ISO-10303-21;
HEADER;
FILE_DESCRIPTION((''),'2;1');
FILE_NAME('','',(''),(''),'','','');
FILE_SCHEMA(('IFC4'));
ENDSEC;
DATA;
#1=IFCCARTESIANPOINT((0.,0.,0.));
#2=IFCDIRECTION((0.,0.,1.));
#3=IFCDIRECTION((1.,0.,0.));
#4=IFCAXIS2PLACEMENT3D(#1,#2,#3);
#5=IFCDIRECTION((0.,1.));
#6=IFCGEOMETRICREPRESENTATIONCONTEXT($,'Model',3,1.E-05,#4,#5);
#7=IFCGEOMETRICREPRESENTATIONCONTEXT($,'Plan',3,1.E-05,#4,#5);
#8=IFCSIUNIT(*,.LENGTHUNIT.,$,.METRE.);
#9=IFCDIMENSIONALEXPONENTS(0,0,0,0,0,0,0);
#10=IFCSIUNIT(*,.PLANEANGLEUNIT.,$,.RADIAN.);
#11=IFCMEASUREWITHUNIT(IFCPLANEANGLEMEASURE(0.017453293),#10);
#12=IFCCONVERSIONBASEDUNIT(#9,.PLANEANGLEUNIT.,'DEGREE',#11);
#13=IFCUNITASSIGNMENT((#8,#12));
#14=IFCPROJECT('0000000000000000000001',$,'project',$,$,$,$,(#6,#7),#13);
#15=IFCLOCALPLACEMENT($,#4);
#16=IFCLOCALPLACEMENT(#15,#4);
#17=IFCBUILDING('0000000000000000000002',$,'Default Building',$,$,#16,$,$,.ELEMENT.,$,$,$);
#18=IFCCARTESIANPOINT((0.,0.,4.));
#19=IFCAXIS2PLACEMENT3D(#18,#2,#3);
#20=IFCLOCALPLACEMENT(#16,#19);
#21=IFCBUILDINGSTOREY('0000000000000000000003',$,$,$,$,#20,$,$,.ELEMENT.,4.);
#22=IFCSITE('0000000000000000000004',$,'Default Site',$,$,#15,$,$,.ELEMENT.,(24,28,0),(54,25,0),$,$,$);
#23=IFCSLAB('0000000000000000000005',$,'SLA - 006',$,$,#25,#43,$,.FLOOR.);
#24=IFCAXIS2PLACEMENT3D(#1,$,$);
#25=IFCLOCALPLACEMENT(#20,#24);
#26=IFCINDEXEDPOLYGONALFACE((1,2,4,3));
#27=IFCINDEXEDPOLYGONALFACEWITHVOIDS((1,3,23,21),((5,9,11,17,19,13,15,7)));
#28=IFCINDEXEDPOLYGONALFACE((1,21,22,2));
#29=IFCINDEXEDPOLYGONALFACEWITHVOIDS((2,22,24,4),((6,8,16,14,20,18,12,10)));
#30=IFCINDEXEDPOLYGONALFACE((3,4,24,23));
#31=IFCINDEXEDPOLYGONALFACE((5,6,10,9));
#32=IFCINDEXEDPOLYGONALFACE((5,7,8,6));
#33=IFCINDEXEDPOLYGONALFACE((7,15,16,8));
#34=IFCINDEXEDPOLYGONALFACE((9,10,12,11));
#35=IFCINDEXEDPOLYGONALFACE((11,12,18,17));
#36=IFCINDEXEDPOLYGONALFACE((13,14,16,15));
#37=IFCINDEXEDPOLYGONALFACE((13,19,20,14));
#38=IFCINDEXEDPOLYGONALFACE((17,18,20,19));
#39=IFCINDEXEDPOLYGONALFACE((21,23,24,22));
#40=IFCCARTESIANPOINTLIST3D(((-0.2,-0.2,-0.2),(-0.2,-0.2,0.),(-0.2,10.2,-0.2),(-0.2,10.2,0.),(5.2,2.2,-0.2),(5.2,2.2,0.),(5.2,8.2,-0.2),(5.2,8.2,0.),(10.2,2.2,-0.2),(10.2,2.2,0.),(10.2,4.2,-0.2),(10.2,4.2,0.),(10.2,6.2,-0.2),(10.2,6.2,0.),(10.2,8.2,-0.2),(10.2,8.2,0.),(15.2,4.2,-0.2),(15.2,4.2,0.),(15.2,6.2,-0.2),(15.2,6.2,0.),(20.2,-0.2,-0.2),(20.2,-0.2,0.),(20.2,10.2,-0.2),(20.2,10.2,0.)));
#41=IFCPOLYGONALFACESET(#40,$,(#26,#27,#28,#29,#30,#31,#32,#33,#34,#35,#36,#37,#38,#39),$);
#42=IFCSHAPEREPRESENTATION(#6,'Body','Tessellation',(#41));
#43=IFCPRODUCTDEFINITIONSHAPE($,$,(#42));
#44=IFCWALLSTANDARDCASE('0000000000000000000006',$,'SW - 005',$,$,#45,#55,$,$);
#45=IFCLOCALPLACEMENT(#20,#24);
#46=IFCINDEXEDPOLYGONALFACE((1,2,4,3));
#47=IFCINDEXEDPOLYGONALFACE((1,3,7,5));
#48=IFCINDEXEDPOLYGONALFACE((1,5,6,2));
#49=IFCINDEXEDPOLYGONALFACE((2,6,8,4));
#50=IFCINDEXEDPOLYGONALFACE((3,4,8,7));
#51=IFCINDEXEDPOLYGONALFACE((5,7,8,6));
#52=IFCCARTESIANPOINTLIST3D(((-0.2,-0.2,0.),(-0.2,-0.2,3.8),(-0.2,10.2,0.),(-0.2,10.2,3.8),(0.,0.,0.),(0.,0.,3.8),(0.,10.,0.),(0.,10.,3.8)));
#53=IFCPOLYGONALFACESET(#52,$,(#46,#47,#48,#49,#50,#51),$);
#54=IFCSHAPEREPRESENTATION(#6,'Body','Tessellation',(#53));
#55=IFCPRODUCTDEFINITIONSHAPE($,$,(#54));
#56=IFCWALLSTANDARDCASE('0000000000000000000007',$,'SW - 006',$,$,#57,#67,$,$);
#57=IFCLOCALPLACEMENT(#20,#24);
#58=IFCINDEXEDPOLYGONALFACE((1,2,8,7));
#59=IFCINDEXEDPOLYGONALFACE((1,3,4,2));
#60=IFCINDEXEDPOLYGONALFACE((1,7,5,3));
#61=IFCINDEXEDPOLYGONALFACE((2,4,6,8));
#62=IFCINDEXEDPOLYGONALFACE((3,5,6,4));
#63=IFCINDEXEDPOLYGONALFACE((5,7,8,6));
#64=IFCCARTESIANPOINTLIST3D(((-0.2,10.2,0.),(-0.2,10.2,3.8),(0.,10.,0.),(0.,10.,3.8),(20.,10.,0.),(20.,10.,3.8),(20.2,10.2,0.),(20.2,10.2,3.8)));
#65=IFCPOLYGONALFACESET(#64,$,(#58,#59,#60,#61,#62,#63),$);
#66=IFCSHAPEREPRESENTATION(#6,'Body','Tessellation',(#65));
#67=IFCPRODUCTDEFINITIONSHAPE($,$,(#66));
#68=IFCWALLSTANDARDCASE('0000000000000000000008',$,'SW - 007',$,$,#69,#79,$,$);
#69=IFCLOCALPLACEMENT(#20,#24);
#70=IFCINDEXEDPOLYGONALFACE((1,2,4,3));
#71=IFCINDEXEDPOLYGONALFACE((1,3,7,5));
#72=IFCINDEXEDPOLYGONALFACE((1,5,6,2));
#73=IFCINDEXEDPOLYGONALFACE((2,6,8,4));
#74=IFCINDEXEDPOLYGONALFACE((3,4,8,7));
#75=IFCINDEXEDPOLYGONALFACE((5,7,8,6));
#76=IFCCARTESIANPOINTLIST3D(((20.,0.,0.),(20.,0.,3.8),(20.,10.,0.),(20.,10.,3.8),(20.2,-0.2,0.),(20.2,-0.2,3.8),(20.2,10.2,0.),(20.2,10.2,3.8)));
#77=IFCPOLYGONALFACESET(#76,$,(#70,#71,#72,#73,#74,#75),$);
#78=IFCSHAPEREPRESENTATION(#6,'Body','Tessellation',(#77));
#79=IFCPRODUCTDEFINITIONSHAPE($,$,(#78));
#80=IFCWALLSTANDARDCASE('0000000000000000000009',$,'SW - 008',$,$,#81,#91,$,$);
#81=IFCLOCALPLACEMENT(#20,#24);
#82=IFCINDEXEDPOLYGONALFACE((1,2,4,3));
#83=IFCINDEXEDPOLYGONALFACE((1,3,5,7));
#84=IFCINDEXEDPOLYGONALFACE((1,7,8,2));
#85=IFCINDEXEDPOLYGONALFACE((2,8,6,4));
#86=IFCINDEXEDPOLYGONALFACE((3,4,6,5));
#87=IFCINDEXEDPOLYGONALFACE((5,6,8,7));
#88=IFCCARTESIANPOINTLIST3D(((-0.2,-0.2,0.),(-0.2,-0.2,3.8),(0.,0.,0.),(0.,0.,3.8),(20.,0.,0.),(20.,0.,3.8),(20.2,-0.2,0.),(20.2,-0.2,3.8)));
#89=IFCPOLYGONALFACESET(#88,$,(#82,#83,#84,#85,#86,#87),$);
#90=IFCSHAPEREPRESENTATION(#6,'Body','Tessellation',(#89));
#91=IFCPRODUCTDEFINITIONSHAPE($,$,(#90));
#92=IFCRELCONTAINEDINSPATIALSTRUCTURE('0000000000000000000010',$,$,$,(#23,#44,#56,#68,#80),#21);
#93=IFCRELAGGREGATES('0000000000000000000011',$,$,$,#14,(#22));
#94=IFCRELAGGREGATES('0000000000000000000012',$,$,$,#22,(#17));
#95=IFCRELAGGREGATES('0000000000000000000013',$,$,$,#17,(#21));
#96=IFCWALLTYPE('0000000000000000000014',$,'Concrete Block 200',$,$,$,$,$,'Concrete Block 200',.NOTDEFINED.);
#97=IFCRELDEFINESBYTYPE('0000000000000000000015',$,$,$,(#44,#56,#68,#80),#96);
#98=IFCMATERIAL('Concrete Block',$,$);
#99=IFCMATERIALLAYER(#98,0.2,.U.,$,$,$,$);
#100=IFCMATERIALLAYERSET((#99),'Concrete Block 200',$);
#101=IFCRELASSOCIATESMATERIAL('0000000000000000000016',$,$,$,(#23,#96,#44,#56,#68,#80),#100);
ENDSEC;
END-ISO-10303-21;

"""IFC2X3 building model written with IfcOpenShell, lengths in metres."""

from ifc_helpers import new_model, entity, si_unit, converted_unit, direction, frame, origin_with_axes, place, context, project, spatial, polyline, outline, extrude, material, layer, layer_set, layer_usage, type_object, element, save


model = new_model("IFC2X3")

# Units and contexts
model_context = context("Model", 3, precision=1e-05, world=origin_with_axes(), true_north=direction((0.0, 1.0)))
plan_context = context("Plan", 3, precision=1e-05, world=origin_with_axes(), true_north=direction((0.0, 1.0)))
ifc_project = project(units=[si_unit("LENGTHUNIT", "METRE"), converted_unit("PLANEANGLEUNIT", "DEGREE", entity("IfcPlaneAngleMeasure", 0.017453293), si_unit("PLANEANGLEUNIT", "RADIAN"), dimensions=[0, 0, 0, 0, 0, 0, 0])], contexts=[model_context, plan_context])

# Site, building, storey
site_placement = place(None, origin_with_axes())
site = spatial("IfcSite", under=ifc_project, at=site_placement, Name="Default Site", CompositionType="ELEMENT", RefLatitude=(24, 28, 0), RefLongitude=(54, 25, 0))
building_placement = place(site_placement, origin_with_axes())
building = spatial("IfcBuilding", under=site, at=building_placement, Name="Default Building", CompositionType="ELEMENT")
storey_placement = place(building_placement, frame((0.0, 0.0, 4.0), z_axis=(0.0, 0.0, 1.0), x_axis=(1.0, 0.0, 0.0)))
storey = spatial("IfcBuildingStorey", under=building, at=storey_placement, CompositionType="ELEMENT", Elevation=4.0)

# Slab, opening
ifc_material = material(Name="Concrete Block")
ifc_layer = layer(ifc_material, 0.2, ventilated="UNKNOWN")
ifc_layer_set = layer_set([ifc_layer], Name="Concrete Block 200")
ifc_layer_usage_1 = layer_usage(ifc_layer_set, "AXIS3", "NEGATIVE", 0.2)
slab_placement = place(storey_placement, frame((20.2, 10.2, -0.2), z_axis=(0.0, 0.0, 1.0), x_axis=(-1.0, 0.0, 0.0)))
slab = element("IfcSlab", 1, at=slab_placement, inside=storey, material=ifc_layer_usage_1, Name="SLA - 006", PredefinedType="FLOOR", context=model_context, shape_type="SweptSolid", body=[
    extrude(outline(polyline([(0.0, 0.0), (20.4, 0.0), (20.4, 10.4), (0.0, 10.4), (0.0, 0.0)])), origin_with_axes(), (0.0, 0.0, 1.0), 0.2),
])
opening_placement = place(slab_placement, origin_with_axes())
element("IfcOpeningElement", 2, at=opening_placement, cuts=slab, context=model_context, shape_type="SweptSolid", body=[
    extrude(outline(polyline([(10.0, 8.0), (15.0, 8.0), (15.0, 2.0), (10.0, 2.0), (10.0, 4.0), (5.0, 4.0), (5.0, 6.0), (10.0, 6.0), (10.0, 8.0)])), origin_with_axes(), (0.0, 0.0, 1.0), 0.2),
])

# Walls
ifc_layer_usage_2 = layer_usage(ifc_layer_set, "AXIS2", "POSITIVE", 0.0)
wall_type = type_object("IfcWallType", Name="Concrete Block 200", ElementType="Concrete Block 200", PredefinedType="NOTDEFINED", material=ifc_layer_set)
wall_1_placement = place(storey_placement, frame((0.0, 0.0, 0.0), z_axis=(0.0, 0.0, 1.0), x_axis=(0.0, 1.0, 0.0)))
element("IfcWallStandardCase", 3, at=wall_1_placement, inside=storey, type_object=wall_type, material=ifc_layer_usage_2, Name="SW - 005", context=model_context, shape_type="SweptSolid", body=[
    extrude(outline(polyline([(0.0, 0.0), (10.0, 0.0), (10.2, 0.2), (-0.2, 0.2), (0.0, 0.0)])), origin_with_axes(), (0.0, 0.0, 1.0), 3.8),
])
ifc_layer_usage_3 = layer_usage(ifc_layer_set, "AXIS2", "POSITIVE", 0.0)
wall_2_placement = place(storey_placement, frame((0.0, 10.0, 0.0), z_axis=(0.0, 0.0, 1.0), x_axis=(1.0, 0.0, 0.0)))
element("IfcWallStandardCase", 4, at=wall_2_placement, inside=storey, type_object=wall_type, material=ifc_layer_usage_3, Name="SW - 006", context=model_context, shape_type="SweptSolid", body=[
    extrude(outline(polyline([(0.0, 0.0), (20.0, 0.0), (20.2, 0.2), (-0.2, 0.2), (0.0, 0.0)])), origin_with_axes(), (0.0, 0.0, 1.0), 3.8),
])
ifc_layer_usage_4 = layer_usage(ifc_layer_set, "AXIS2", "POSITIVE", 0.0)
wall_3_placement = place(storey_placement, frame((20.0, 10.0, 0.0), z_axis=(0.0, 0.0, 1.0), x_axis=(0.0, -1.0, 0.0)))
element("IfcWallStandardCase", 5, at=wall_3_placement, inside=storey, type_object=wall_type, material=ifc_layer_usage_4, Name="SW - 007", context=model_context, shape_type="SweptSolid", body=[
    extrude(outline(polyline([(0.0, 0.0), (10.0, 0.0), (10.2, 0.2), (-0.2, 0.2), (0.0, 0.0)])), origin_with_axes(), (0.0, 0.0, 1.0), 3.8),
])
ifc_layer_usage_5 = layer_usage(ifc_layer_set, "AXIS2", "POSITIVE", 0.0)
wall_4_placement = place(storey_placement, frame((20.0, 0.0, 0.0), z_axis=(0.0, 0.0, 1.0), x_axis=(-1.0, 0.0, 0.0)))
element("IfcWallStandardCase", 6, at=wall_4_placement, inside=storey, type_object=wall_type, material=ifc_layer_usage_5, Name="SW - 008", context=model_context, shape_type="SweptSolid", body=[
    extrude(outline(polyline([(0.0, 0.0), (20.0, 0.0), (20.2, 0.2), (-0.2, 0.2), (0.0, 0.0)])), origin_with_axes(), (0.0, 0.0, 1.0), 3.8),
])

save(model, "model.ifc")
